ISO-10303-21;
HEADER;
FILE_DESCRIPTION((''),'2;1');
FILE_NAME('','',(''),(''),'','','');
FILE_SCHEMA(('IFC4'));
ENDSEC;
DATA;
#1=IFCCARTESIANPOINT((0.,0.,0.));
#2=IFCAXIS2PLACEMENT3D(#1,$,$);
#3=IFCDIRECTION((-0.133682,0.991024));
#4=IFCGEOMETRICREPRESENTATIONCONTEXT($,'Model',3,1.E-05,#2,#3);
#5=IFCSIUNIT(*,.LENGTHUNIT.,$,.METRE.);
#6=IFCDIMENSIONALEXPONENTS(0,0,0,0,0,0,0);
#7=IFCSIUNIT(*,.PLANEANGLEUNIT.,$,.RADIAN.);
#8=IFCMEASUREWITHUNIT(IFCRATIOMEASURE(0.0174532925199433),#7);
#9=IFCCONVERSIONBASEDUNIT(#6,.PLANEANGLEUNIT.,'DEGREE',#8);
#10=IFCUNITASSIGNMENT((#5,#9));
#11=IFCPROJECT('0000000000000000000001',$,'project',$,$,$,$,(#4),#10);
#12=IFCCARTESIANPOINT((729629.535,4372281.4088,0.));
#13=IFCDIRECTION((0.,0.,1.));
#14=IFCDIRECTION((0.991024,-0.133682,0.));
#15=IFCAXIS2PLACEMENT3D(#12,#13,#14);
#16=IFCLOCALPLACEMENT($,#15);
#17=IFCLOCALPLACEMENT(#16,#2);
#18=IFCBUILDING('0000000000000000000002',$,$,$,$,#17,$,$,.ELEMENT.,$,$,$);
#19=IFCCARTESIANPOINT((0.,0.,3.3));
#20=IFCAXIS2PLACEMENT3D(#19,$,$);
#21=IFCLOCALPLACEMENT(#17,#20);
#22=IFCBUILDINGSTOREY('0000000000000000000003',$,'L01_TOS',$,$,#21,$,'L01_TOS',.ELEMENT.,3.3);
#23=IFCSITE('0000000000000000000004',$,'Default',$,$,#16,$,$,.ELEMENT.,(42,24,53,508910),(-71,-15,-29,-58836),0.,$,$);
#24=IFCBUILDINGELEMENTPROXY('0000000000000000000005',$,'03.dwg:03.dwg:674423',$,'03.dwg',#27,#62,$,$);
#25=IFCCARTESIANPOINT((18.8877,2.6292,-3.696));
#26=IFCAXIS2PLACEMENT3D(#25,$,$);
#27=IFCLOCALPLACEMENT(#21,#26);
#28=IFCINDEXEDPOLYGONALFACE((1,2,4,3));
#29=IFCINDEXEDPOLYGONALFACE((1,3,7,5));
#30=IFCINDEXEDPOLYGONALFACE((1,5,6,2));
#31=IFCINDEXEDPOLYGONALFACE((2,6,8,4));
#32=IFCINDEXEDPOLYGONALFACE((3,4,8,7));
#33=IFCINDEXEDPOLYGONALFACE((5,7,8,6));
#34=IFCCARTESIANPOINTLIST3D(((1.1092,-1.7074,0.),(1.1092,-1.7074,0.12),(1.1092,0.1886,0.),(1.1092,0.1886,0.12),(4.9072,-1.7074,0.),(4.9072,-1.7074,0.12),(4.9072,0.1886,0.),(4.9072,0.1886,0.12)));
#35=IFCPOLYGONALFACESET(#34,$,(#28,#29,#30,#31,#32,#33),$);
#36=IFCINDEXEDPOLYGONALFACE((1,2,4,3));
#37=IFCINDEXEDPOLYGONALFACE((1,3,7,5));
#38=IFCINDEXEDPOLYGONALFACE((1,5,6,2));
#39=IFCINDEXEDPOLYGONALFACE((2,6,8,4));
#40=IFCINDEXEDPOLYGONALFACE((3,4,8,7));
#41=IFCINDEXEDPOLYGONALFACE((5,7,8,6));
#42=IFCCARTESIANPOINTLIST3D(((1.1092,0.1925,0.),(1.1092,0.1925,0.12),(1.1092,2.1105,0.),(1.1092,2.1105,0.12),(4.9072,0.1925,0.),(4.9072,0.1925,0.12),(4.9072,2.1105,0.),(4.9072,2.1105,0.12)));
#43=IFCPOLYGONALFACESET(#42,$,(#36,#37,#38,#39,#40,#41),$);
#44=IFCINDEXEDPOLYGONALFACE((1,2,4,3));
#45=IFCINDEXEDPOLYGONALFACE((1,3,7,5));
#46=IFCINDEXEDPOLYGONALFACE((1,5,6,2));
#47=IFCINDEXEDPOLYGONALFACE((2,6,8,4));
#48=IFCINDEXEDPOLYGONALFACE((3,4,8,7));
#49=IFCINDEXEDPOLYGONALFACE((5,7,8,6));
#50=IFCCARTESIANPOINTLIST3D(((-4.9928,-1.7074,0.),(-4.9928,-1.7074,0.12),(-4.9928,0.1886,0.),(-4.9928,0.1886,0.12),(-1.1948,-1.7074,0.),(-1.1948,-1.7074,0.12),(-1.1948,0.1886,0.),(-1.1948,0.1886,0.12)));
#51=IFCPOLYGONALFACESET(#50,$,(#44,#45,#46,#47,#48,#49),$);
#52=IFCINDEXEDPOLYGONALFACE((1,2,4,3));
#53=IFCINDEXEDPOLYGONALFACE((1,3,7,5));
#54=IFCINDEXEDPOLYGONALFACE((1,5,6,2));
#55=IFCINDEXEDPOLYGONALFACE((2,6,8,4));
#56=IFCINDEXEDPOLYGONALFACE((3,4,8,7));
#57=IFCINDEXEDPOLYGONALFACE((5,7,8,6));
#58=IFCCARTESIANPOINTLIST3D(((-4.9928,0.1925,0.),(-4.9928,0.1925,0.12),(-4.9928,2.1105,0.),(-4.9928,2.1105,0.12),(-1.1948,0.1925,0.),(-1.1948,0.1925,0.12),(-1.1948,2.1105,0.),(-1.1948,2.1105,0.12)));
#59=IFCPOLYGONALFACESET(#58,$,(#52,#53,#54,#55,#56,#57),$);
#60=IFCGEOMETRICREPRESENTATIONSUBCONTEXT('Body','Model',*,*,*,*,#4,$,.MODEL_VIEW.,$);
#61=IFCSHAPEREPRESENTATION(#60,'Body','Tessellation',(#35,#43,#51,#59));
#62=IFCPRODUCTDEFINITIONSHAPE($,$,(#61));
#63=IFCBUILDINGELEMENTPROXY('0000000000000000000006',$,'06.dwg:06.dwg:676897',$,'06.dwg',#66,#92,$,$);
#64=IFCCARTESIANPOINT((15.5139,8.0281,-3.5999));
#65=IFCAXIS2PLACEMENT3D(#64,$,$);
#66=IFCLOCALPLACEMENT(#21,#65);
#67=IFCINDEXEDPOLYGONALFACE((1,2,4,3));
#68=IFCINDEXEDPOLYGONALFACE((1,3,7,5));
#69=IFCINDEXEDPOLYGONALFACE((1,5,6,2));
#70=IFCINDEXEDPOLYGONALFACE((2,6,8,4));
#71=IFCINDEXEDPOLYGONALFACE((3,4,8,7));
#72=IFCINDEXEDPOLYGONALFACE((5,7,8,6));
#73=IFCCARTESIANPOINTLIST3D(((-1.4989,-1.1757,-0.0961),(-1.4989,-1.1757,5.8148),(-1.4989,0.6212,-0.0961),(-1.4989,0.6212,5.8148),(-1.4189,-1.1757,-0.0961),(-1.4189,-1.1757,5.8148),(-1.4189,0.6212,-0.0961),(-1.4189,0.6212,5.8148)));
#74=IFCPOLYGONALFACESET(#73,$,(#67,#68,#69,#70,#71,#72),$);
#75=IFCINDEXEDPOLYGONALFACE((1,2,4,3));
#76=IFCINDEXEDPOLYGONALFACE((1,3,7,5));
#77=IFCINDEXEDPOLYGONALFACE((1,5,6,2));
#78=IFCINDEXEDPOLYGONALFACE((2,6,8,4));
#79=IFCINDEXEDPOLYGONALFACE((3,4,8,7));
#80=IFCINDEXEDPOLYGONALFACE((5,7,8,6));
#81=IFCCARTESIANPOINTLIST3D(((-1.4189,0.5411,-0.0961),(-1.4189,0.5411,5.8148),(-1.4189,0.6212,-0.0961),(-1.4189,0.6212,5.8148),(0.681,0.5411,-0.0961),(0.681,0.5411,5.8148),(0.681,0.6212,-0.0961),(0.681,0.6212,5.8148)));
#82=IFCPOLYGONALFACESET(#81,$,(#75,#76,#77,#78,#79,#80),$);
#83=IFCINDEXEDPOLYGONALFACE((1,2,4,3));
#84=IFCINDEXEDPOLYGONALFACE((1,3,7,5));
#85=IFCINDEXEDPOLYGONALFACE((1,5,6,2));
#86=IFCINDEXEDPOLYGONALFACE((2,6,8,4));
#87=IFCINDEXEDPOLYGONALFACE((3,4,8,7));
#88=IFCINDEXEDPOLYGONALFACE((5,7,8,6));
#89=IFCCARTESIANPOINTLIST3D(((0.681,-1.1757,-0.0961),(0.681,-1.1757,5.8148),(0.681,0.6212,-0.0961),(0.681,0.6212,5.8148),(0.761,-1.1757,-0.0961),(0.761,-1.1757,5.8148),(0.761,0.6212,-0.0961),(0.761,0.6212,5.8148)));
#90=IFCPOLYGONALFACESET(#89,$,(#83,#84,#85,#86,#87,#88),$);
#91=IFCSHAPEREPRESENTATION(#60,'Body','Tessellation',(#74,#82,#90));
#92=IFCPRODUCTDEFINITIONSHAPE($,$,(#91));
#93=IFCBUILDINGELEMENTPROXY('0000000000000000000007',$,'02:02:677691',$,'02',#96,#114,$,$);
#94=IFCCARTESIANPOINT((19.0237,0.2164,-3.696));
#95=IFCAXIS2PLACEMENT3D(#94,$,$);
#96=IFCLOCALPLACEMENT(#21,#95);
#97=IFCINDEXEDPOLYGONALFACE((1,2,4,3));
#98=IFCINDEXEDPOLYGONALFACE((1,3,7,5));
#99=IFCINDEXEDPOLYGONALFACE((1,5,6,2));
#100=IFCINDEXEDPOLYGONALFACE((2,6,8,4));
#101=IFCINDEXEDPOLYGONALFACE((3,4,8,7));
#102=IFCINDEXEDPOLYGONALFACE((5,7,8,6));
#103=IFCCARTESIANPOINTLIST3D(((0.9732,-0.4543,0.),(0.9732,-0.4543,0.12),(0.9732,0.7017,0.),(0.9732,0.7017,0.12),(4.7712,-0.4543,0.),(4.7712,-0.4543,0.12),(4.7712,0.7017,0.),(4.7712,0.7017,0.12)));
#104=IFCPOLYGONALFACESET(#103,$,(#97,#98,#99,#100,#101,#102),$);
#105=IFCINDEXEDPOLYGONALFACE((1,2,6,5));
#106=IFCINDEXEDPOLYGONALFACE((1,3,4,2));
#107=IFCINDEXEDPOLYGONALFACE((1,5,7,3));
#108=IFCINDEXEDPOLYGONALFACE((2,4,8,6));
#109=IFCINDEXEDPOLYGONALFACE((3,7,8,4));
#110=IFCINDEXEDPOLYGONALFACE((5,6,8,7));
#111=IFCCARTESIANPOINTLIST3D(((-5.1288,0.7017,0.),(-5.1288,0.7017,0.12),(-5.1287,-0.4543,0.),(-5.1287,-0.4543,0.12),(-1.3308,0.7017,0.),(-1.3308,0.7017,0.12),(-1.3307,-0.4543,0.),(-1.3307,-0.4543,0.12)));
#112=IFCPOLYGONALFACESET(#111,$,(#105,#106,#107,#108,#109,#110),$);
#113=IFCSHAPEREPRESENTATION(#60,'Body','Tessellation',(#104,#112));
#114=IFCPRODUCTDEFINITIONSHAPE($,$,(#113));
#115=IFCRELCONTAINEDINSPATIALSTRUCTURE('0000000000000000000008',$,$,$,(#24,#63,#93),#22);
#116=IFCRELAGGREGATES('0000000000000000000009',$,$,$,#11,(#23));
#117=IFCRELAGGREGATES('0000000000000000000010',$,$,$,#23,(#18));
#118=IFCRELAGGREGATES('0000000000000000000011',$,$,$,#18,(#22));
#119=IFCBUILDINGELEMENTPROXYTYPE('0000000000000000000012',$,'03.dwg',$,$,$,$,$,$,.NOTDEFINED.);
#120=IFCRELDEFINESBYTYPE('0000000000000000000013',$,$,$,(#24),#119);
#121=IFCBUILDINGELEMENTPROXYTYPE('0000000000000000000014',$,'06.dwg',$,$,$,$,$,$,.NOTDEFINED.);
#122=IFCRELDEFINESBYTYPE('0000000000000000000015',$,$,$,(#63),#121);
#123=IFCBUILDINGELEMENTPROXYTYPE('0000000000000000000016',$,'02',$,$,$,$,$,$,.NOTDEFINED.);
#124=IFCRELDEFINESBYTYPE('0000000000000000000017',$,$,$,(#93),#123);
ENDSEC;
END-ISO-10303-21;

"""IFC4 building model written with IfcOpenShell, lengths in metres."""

from ifc_helpers import new_model, entity, si_unit, converted_unit, direction, frame, frame_2d, origin, origin_2d_with_axis, place, context, subcontext, project, spatial, rectangle, extrude, source, transform, mapped, type_object, type_shapes, element, save


model = new_model("IFC4")

# Units and contexts
model_context = context("Model", 3, precision=1e-05, world=origin(), true_north=direction((-0.133682, 0.991024)))
body_context = subcontext(model_context, "Body", "Model", "MODEL_VIEW")
ifc_project = project(units=[si_unit("LENGTHUNIT", "METRE"), converted_unit("PLANEANGLEUNIT", "DEGREE", entity("IfcRatioMeasure", 0.0174532925199433), si_unit("PLANEANGLEUNIT", "RADIAN"), dimensions=[0, 0, 0, 0, 0, 0, 0])], contexts=[model_context])

# Site, building, storey
site_placement = place(None, frame((729629.535, 4372281.4088, 0.0), z_axis=(0.0, 0.0, 1.0), x_axis=(0.991024, -0.133682, 0.0)))
site = spatial("IfcSite", under=ifc_project, at=site_placement, Name="Default", CompositionType="ELEMENT", RefLatitude=(42, 24, 53, 508910), RefLongitude=(-71, -15, -29, -58836), RefElevation=0.0)
building_placement = place(site_placement, origin())
building = spatial("IfcBuilding", under=site, at=building_placement, CompositionType="ELEMENT")
storey_placement = place(building_placement, frame((0.0, 0.0, 3.3)))
storey = spatial("IfcBuildingStorey", under=building, at=storey_placement, Name="L01_TOS", LongName="L01_TOS", CompositionType="ELEMENT", Elevation=3.3)

# Building element proxies
building_element_proxy_type_1 = type_object("IfcBuildingElementProxyType", Name="03.dwg")
shared_shape_1 = source(origin(), body_context, "Body", "SweptSolid", [
    extrude(rectangle(XDim=1.896, YDim=3.798, at=frame_2d((0.0, 0.0), x_axis=(1.0, 0.0))), frame((3.0082, -0.7594, 0.0), z_axis=(0.0, 0.0, 1.0), x_axis=(-0.000004, -1.0, 0.0)), (0.0, 0.0, 1.0), 0.12),
    extrude(rectangle(XDim=1.918, YDim=3.798, at=frame_2d((0.0, 0.0), x_axis=(1.0, 0.0))), frame((3.0082, 1.1515, 0.0), z_axis=(0.0, 0.0, 1.0), x_axis=(-0.000004, -1.0, 0.0)), (0.0, 0.0, 1.0), 0.12),
    extrude(rectangle(XDim=1.896, YDim=3.798, at=frame_2d((0.0, 0.0), x_axis=(1.0, 0.0))), frame((-3.0938, -0.7594, 0.0), z_axis=(0.0, 0.0, 1.0), x_axis=(0.000004, -1.0, 0.0)), (0.0, 0.0, 1.0), 0.12),
    extrude(rectangle(XDim=1.918, YDim=3.798, at=frame_2d((0.0, 0.0), x_axis=(1.0, 0.0))), frame((-3.0938, 1.1515, 0.0), z_axis=(0.0, 0.0, 1.0), x_axis=(0.000004, -1.0, 0.0)), (0.0, 0.0, 1.0), 0.12),
])
type_shapes(building_element_proxy_type_1, [shared_shape_1])
proxy_1_placement = place(storey_placement, frame((18.8877, 2.6292, -3.696)))
element("IfcBuildingElementProxy", 1, at=proxy_1_placement, inside=storey, type_object=building_element_proxy_type_1, Name="03.dwg:03.dwg:674423", ObjectType="03.dwg", context=body_context, shape_type="MappedRepresentation", body=[
    mapped(shared_shape_1, transform((0.0, 0.0, 0.0), scale=1.0)),
])
building_element_proxy_type_2 = type_object("IfcBuildingElementProxyType", Name="06.dwg")
shared_shape_2 = source(origin(), body_context, "Body", "SweptSolid", [
    extrude(rectangle(XDim=0.08, YDim=1.7968, at=origin_2d_with_axis()), frame((-1.4589, -0.2772, -0.0961), z_axis=(0.0, 0.0, 1.0), x_axis=(-1.0, 0.0, 0.0)), (0.0, 0.0, 1.0), 5.9109),
    extrude(rectangle(XDim=2.0999, YDim=0.0801, at=origin_2d_with_axis()), frame((-0.3689, 0.5811, -0.0961), z_axis=(0.0, 0.0, 1.0), x_axis=(-1.0, 0.0, 0.0)), (0.0, 0.0, 1.0), 5.9109),
    extrude(rectangle(XDim=0.08, YDim=1.7968, at=origin_2d_with_axis()), frame((0.721, -0.2772, -0.0961), z_axis=(0.0, 0.0, 1.0), x_axis=(-1.0, 0.0, 0.0)), (0.0, 0.0, 1.0), 5.9109),
])
type_shapes(building_element_proxy_type_2, [shared_shape_2])
proxy_2_placement = place(storey_placement, frame((15.5139, 8.0281, -3.5999)))
element("IfcBuildingElementProxy", 2, at=proxy_2_placement, inside=storey, type_object=building_element_proxy_type_2, Name="06.dwg:06.dwg:676897", ObjectType="06.dwg", context=body_context, shape_type="MappedRepresentation", body=[
    mapped(shared_shape_2, transform((0.0, 0.0, 0.0), scale=1.0)),
])
building_element_proxy_type_3 = type_object("IfcBuildingElementProxyType", Name="02")
shared_shape_3 = source(origin(), body_context, "Body", "SweptSolid", [
    extrude(rectangle(XDim=1.156, YDim=3.798, at=frame_2d((0.0, 0.0), x_axis=(1.0, 0.0))), frame((2.8722, 0.1237, 0.0), z_axis=(0.0, 0.0, 1.0), x_axis=(-0.000004, -1.0, 0.0)), (0.0, 0.0, 1.0), 0.12),
    extrude(rectangle(XDim=1.156, YDim=3.798, at=frame_2d((0.0, 0.0), x_axis=(1.0, 0.0))), frame((-3.2297, 0.1237, 0.0), z_axis=(0.0, 0.0, 1.0), x_axis=(0.000004, -1.0, 0.0)), (0.0, 0.0, 1.0), 0.12),
])
type_shapes(building_element_proxy_type_3, [shared_shape_3])
proxy_3_placement = place(storey_placement, frame((19.0237, 0.2164, -3.696)))
element("IfcBuildingElementProxy", 3, at=proxy_3_placement, inside=storey, type_object=building_element_proxy_type_3, Name="02:02:677691", ObjectType="02", context=body_context, shape_type="MappedRepresentation", body=[
    mapped(shared_shape_3, transform((0.0, 0.0, 0.0), scale=1.0)),
])

save(model, "model.ifc")
